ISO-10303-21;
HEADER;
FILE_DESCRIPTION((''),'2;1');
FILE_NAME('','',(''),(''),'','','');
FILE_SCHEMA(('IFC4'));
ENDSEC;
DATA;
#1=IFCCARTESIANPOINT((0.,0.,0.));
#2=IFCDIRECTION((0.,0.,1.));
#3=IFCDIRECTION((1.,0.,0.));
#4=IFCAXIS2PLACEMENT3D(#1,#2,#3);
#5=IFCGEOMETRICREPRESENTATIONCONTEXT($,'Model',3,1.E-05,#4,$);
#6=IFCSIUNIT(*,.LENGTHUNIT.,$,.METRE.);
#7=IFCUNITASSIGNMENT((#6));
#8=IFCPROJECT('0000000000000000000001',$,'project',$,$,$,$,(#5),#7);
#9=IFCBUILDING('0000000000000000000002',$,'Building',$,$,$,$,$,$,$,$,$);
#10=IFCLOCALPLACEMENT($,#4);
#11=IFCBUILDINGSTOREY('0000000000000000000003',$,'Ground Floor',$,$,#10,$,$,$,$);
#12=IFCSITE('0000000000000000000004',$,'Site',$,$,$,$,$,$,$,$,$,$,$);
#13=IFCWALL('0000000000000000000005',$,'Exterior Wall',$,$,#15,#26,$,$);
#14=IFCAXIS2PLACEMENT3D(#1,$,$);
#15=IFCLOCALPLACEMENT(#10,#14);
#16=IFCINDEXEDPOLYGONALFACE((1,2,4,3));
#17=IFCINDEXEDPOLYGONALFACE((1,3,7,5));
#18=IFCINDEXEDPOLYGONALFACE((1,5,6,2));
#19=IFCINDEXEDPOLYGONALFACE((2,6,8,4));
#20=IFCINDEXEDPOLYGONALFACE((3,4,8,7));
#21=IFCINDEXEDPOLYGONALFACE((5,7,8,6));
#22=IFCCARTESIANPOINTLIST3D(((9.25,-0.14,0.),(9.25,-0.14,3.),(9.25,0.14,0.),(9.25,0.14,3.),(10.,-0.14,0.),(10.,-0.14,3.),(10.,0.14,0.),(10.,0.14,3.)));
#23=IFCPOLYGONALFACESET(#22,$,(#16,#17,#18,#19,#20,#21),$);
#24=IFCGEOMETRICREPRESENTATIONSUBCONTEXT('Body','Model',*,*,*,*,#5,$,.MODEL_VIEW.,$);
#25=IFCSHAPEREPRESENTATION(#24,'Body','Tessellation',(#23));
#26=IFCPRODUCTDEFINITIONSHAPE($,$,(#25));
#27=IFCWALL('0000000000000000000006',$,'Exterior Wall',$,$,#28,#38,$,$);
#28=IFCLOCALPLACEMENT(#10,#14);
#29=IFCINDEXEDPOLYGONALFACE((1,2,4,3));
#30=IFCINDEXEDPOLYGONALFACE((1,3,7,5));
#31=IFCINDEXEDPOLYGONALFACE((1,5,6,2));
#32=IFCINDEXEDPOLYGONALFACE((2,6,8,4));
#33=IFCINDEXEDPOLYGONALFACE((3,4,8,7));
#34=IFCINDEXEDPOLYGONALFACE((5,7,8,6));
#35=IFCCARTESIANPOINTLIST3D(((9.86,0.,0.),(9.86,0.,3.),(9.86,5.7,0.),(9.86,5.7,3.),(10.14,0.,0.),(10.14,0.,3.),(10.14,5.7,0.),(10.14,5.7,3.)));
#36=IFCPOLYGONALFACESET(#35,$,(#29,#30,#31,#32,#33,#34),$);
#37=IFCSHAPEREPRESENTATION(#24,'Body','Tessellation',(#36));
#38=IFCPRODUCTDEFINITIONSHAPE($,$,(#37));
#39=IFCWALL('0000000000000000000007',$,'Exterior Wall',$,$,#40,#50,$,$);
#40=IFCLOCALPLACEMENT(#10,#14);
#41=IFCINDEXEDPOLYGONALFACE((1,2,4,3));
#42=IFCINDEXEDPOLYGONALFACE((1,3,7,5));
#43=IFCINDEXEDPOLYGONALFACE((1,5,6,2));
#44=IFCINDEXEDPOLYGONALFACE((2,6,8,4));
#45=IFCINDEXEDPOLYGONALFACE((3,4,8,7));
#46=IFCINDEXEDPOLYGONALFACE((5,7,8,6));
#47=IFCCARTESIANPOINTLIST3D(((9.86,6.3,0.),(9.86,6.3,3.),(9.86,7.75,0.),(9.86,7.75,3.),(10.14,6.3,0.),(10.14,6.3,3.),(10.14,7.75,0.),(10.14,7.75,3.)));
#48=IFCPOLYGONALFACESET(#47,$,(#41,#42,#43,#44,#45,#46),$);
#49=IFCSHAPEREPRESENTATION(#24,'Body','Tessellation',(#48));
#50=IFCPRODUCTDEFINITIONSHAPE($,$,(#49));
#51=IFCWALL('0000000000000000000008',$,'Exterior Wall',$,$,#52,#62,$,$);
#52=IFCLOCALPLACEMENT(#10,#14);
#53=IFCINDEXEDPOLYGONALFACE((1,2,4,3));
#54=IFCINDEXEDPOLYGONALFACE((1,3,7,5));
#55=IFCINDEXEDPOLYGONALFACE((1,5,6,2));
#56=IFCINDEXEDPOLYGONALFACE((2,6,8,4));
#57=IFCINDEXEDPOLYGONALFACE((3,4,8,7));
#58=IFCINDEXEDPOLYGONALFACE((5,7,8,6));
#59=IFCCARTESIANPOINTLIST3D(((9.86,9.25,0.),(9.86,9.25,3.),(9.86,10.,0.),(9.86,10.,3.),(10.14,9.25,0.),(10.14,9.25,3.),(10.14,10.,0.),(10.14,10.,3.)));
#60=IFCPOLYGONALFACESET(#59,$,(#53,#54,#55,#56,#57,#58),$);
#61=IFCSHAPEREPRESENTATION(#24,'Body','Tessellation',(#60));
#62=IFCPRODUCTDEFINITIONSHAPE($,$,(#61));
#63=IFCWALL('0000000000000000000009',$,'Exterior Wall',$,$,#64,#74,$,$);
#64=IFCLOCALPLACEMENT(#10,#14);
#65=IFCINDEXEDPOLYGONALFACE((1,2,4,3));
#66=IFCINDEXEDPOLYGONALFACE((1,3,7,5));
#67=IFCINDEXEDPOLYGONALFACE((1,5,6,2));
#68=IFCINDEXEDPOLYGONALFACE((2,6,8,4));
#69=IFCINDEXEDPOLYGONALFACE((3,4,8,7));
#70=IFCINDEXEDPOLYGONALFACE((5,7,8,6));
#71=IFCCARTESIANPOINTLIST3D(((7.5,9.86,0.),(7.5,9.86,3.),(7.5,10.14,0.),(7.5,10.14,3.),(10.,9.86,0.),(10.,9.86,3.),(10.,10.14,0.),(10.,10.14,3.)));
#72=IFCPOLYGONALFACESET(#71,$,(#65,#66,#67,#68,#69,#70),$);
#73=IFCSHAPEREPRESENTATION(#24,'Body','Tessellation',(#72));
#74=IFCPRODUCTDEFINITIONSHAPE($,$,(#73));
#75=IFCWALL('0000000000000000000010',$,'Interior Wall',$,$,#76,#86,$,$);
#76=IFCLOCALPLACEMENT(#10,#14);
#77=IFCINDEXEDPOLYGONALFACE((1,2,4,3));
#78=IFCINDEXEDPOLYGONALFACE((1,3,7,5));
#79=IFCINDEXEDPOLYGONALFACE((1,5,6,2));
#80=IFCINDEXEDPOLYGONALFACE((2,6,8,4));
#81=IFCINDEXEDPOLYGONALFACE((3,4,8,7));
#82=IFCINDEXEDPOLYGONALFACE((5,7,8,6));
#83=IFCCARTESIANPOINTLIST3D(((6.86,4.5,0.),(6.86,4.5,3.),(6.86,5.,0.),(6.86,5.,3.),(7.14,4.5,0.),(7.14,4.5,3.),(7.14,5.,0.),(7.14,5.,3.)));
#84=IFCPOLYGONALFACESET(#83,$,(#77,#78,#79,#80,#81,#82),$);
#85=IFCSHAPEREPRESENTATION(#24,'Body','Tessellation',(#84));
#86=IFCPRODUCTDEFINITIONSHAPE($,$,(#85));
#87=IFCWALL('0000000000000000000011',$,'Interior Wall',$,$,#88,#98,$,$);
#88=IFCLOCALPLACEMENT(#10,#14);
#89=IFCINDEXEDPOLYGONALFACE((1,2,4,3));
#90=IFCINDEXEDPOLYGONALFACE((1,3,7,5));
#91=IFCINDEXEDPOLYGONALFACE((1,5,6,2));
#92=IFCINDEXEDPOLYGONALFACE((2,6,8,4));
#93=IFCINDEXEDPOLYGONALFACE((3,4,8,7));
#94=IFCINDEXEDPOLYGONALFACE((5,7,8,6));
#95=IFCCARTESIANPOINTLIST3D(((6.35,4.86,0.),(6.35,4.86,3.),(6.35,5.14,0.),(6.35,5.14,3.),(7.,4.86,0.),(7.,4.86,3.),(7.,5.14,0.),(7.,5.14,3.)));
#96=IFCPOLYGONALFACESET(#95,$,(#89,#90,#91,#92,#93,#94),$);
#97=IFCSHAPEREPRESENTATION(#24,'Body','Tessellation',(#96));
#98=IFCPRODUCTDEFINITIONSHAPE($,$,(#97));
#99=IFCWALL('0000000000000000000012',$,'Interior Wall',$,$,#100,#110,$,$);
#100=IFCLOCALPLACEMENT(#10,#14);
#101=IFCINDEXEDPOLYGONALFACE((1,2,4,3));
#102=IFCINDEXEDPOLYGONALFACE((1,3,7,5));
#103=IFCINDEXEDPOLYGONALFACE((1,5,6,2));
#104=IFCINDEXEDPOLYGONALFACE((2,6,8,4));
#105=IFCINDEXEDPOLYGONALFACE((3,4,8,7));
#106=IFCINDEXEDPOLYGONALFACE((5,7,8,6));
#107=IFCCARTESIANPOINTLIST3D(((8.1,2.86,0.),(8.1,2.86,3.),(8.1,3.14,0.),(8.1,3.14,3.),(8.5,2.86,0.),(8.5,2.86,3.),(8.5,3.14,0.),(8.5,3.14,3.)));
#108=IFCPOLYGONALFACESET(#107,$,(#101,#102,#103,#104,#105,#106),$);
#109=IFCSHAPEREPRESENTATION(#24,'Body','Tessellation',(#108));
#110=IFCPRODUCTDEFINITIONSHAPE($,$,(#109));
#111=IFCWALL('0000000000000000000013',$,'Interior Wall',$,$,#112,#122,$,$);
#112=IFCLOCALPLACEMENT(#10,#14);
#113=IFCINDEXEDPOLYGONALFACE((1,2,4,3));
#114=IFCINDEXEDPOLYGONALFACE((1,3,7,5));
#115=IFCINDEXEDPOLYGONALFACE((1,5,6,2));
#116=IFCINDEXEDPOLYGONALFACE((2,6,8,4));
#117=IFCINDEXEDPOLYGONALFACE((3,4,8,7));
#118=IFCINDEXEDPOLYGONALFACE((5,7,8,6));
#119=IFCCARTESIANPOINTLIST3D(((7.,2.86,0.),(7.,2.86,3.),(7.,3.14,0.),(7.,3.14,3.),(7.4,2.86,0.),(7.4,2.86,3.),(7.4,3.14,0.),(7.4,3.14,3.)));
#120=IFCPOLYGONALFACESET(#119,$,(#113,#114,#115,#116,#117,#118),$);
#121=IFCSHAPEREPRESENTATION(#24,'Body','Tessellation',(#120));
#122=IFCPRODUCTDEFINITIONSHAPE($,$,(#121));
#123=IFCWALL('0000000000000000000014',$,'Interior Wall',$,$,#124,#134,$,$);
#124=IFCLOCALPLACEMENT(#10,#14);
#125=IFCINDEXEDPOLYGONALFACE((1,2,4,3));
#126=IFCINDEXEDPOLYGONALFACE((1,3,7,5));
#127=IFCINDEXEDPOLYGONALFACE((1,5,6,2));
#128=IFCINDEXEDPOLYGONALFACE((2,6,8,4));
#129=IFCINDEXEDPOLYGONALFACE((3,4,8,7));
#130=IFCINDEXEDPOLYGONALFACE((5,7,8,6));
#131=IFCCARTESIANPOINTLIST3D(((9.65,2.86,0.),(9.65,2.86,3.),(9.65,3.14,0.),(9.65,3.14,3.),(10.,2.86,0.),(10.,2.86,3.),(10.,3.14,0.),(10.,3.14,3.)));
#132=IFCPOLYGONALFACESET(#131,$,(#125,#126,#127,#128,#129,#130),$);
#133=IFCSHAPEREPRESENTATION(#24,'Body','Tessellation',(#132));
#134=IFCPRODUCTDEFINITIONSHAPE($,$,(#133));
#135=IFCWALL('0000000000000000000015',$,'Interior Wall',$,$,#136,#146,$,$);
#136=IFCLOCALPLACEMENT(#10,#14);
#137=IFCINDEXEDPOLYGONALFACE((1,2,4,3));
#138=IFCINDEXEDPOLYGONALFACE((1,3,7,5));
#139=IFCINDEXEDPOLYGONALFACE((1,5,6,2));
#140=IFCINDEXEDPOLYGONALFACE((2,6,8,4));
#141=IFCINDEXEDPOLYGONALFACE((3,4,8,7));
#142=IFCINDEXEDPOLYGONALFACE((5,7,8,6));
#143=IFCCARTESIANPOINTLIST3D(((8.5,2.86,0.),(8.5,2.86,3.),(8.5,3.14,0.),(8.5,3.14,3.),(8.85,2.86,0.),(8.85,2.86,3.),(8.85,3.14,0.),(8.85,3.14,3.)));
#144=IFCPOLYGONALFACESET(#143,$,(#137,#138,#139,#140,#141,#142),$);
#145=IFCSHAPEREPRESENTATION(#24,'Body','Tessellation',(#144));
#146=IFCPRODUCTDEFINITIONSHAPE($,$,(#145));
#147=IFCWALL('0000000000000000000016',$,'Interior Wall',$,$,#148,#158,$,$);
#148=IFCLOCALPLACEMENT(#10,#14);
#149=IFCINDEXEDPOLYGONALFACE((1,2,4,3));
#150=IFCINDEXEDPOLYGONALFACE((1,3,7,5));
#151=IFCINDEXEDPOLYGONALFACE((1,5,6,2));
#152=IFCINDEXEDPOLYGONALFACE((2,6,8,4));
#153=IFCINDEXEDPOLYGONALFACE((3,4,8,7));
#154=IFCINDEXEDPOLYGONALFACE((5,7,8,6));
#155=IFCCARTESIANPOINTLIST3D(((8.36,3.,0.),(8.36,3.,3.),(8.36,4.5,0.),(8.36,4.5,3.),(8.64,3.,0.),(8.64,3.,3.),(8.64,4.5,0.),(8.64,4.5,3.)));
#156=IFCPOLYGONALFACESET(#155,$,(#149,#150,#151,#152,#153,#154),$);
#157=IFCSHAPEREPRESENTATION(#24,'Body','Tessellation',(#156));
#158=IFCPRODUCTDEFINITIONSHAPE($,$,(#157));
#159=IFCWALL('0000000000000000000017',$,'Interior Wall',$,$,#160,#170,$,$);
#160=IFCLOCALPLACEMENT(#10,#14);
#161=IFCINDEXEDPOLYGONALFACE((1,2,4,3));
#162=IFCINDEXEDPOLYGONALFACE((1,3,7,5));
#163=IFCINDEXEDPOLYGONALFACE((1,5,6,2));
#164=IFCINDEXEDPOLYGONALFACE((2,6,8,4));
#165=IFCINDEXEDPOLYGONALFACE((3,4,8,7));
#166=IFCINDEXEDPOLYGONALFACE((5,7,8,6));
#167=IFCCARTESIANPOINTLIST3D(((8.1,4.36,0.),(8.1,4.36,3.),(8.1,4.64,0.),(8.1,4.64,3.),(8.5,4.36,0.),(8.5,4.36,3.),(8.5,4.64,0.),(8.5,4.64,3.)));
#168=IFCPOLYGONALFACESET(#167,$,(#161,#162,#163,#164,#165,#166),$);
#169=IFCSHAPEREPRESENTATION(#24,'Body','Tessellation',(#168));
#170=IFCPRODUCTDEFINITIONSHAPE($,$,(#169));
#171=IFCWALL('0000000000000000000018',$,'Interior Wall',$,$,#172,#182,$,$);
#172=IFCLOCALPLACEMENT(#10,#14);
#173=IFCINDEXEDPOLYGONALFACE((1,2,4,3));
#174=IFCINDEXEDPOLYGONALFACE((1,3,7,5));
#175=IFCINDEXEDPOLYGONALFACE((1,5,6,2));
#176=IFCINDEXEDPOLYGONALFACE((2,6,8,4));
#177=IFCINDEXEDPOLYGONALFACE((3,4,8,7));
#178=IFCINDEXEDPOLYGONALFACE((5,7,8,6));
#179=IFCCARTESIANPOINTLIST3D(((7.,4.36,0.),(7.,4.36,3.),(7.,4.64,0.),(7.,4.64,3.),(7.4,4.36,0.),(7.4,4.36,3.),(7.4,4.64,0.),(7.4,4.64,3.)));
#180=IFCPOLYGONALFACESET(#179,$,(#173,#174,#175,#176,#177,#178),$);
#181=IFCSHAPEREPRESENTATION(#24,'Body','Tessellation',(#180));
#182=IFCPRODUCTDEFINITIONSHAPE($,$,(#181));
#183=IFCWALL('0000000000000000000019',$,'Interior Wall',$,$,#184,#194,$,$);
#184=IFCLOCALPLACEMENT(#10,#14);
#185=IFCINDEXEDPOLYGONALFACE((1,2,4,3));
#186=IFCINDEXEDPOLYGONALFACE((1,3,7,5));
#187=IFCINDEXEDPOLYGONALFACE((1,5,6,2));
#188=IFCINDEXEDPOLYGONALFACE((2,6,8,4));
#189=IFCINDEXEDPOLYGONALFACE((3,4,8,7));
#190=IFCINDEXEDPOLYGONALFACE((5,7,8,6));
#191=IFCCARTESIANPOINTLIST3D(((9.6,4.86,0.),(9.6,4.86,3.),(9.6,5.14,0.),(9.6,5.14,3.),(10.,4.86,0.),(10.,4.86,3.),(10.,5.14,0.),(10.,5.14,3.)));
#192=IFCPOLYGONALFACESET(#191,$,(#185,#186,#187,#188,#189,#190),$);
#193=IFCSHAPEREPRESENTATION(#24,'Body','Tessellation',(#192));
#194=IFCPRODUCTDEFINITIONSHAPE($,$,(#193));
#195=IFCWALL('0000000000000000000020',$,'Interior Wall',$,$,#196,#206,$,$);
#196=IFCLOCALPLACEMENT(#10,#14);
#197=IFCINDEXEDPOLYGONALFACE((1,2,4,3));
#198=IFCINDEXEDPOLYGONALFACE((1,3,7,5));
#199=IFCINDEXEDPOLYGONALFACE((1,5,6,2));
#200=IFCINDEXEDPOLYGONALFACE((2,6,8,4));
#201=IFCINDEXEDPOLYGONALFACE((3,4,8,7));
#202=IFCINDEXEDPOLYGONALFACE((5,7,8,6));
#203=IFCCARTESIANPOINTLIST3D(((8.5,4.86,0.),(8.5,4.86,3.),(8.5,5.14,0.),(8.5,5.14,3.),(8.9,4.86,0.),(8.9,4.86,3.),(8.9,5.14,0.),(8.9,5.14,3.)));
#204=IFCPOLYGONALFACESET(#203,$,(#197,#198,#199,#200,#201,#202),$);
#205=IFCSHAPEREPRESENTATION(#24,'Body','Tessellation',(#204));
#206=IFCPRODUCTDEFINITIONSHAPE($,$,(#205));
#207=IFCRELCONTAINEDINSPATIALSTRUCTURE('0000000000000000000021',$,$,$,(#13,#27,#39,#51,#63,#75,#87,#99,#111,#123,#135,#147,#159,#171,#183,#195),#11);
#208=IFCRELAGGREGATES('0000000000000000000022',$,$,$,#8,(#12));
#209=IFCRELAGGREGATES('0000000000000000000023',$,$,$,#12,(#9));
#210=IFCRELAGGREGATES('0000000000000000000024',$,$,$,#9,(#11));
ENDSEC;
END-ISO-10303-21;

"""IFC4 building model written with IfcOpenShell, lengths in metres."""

from ifc_helpers import new_model, si_unit, frame, origin_with_axes, place, context, subcontext, project, spatial, indexed_curve, outline, extrude, element, save


model = new_model("IFC4")

# Units and contexts
model_context = context("Model", 3, precision=1e-05, world=origin_with_axes())
body_context = subcontext(model_context, "Body", "Model", "MODEL_VIEW")
ifc_project = project(units=[si_unit("LENGTHUNIT", "METRE")], contexts=[model_context])

# Site, building, storey
site = spatial("IfcSite", under=ifc_project, Name="Site")
building = spatial("IfcBuilding", under=site, Name="Building")
storey_placement = place(None, origin_with_axes())
storey = spatial("IfcBuildingStorey", under=building, at=storey_placement, Name="Ground Floor")

# Walls
wall_1_placement = place(storey_placement, frame((9.25, 0.0, 0.0), z_axis=(0.0, 0.0, 1.0), x_axis=(1.0, 0.0, 0.0)))
element("IfcWall", 1, at=wall_1_placement, inside=storey, Name="Exterior Wall", context=body_context, shape_type="SweptSolid", body=[
    extrude(outline(indexed_curve([(0.0, 0.0), (0.0, 0.28), (0.75, 0.28), (0.75, 0.0), (0.0, 0.0)], self_intersect=False)), frame((0.0, -0.14, 0.0), z_axis=(0.0, 0.0, 1.0), x_axis=(1.0, 0.0, 0.0)), (0.0, 0.0, 1.0), 3.0),
])
wall_2_placement = place(storey_placement, frame((10.0, 0.0, 0.0), z_axis=(0.0, 0.0, 1.0), x_axis=(0.0, 1.0, 0.0)))
element("IfcWall", 2, at=wall_2_placement, inside=storey, Name="Exterior Wall", context=body_context, shape_type="SweptSolid", body=[
    extrude(outline(indexed_curve([(0.0, 0.0), (0.0, 0.28), (5.7, 0.28), (5.7, 0.0), (0.0, 0.0)], self_intersect=False)), frame((0.0, -0.14, 0.0), z_axis=(0.0, 0.0, 1.0), x_axis=(1.0, 0.0, 0.0)), (0.0, 0.0, 1.0), 3.0),
])
wall_3_placement = place(storey_placement, frame((10.0, 6.3, 0.0), z_axis=(0.0, 0.0, 1.0), x_axis=(0.0, 1.0, 0.0)))
element("IfcWall", 3, at=wall_3_placement, inside=storey, Name="Exterior Wall", context=body_context, shape_type="SweptSolid", body=[
    extrude(outline(indexed_curve([(0.0, 0.0), (0.0, 0.28), (1.45, 0.28), (1.45, 0.0), (0.0, 0.0)], self_intersect=False)), frame((0.0, -0.14, 0.0), z_axis=(0.0, 0.0, 1.0), x_axis=(1.0, 0.0, 0.0)), (0.0, 0.0, 1.0), 3.0),
])
wall_4_placement = place(storey_placement, frame((10.0, 9.25, 0.0), z_axis=(0.0, 0.0, 1.0), x_axis=(0.0, 1.0, 0.0)))
element("IfcWall", 4, at=wall_4_placement, inside=storey, Name="Exterior Wall", context=body_context, shape_type="SweptSolid", body=[
    extrude(outline(indexed_curve([(0.0, 0.0), (0.0, 0.28), (0.75, 0.28), (0.75, 0.0), (0.0, 0.0)], self_intersect=False)), frame((0.0, -0.14, 0.0), z_axis=(0.0, 0.0, 1.0), x_axis=(1.0, 0.0, 0.0)), (0.0, 0.0, 1.0), 3.0),
])
wall_5_placement = place(storey_placement, frame((10.0, 10.0, 0.0), z_axis=(0.0, 0.0, 1.0), x_axis=(-1.0, 0.0, 0.0)))
element("IfcWall", 5, at=wall_5_placement, inside=storey, Name="Exterior Wall", context=body_context, shape_type="SweptSolid", body=[
    extrude(outline(indexed_curve([(0.0, 0.0), (0.0, 0.28), (2.5, 0.28), (2.5, 0.0), (0.0, 0.0)], self_intersect=False)), frame((0.0, -0.14, 0.0), z_axis=(0.0, 0.0, 1.0), x_axis=(1.0, 0.0, 0.0)), (0.0, 0.0, 1.0), 3.0),
])
wall_6_placement = place(storey_placement, frame((7.0, 4.5, 0.0), z_axis=(0.0, 0.0, 1.0), x_axis=(0.0, 1.0, 0.0)))
element("IfcWall", 6, at=wall_6_placement, inside=storey, Name="Interior Wall", context=body_context, shape_type="SweptSolid", body=[
    extrude(outline(indexed_curve([(0.0, 0.0), (0.0, 0.28), (0.5, 0.28), (0.5, 0.0), (0.0, 0.0)], self_intersect=False)), frame((0.0, -0.14, 0.0), z_axis=(0.0, 0.0, 1.0), x_axis=(1.0, 0.0, 0.0)), (0.0, 0.0, 1.0), 3.0),
])
wall_7_placement = place(storey_placement, frame((7.0, 5.0, 0.0), z_axis=(0.0, 0.0, 1.0), x_axis=(-1.0, 0.0, 0.0)))
element("IfcWall", 7, at=wall_7_placement, inside=storey, Name="Interior Wall", context=body_context, shape_type="SweptSolid", body=[
    extrude(outline(indexed_curve([(0.0, 0.0), (0.0, 0.28), (0.65, 0.28), (0.65, 0.0), (0.0, 0.0)], self_intersect=False)), frame((0.0, -0.14, 0.0), z_axis=(0.0, 0.0, 1.0), x_axis=(1.0, 0.0, 0.0)), (0.0, 0.0, 1.0), 3.0),
])
for number, where, z_axis, x_axis, name in (
    (8, (8.5, 3.0, 0.0), (0.0, 0.0, 1.0), (-1.0, 0.0, 0.0), "Interior Wall"),
    (9, (7.4, 3.0, 0.0), (0.0, 0.0, 1.0), (-1.0, 0.0, 0.0), "Interior Wall"),
):
    element("IfcWall", number, at=place(storey_placement, frame(where, z_axis=z_axis, x_axis=x_axis)), inside=storey, Name=name, context=body_context, shape_type="SweptSolid", body=[
        extrude(outline(indexed_curve([(0.0, 0.0), (0.0, 0.28), (0.4, 0.28), (0.4, 0.0), (0.0, 0.0)], self_intersect=False)), frame((0.0, -0.14, 0.0), z_axis=(0.0, 0.0, 1.0), x_axis=(1.0, 0.0, 0.0)), (0.0, 0.0, 1.0), 3.0),
    ])
for number, where, z_axis, x_axis, name in (
    (10, (10.0, 3.0, 0.0), (0.0, 0.0, 1.0), (-1.0, 0.0, 0.0), "Interior Wall"),
    (11, (8.85, 3.0, 0.0), (0.0, 0.0, 1.0), (-1.0, 0.0, 0.0), "Interior Wall"),
):
    element("IfcWall", number, at=place(storey_placement, frame(where, z_axis=z_axis, x_axis=x_axis)), inside=storey, Name=name, context=body_context, shape_type="SweptSolid", body=[
        extrude(outline(indexed_curve([(0.0, 0.0), (0.0, 0.28), (0.35, 0.28), (0.35, 0.0), (0.0, 0.0)], self_intersect=False)), frame((0.0, -0.14, 0.0), z_axis=(0.0, 0.0, 1.0), x_axis=(1.0, 0.0, 0.0)), (0.0, 0.0, 1.0), 3.0),
    ])
wall_8_placement = place(storey_placement, frame((8.5, 3.0, 0.0), z_axis=(0.0, 0.0, 1.0), x_axis=(0.0, 1.0, 0.0)))
element("IfcWall", 12, at=wall_8_placement, inside=storey, Name="Interior Wall", context=body_context, shape_type="SweptSolid", body=[
    extrude(outline(indexed_curve([(0.0, 0.0), (0.0, 0.28), (1.5, 0.28), (1.5, 0.0), (0.0, 0.0)], self_intersect=False)), frame((0.0, -0.14, 0.0), z_axis=(0.0, 0.0, 1.0), x_axis=(1.0, 0.0, 0.0)), (0.0, 0.0, 1.0), 3.0),
])
for number, where, z_axis, x_axis, name in (
    (13, (8.5, 4.5, 0.0), (0.0, 0.0, 1.0), (-1.0, 0.0, 0.0), "Interior Wall"),
    (14, (7.4, 4.5, 0.0), (0.0, 0.0, 1.0), (-1.0, 0.0, 0.0), "Interior Wall"),
    (15, (10.0, 5.0, 0.0), (0.0, 0.0, 1.0), (-1.0, 0.0, 0.0), "Interior Wall"),
    (16, (8.9, 5.0, 0.0), (0.0, 0.0, 1.0), (-1.0, 0.0, 0.0), "Interior Wall"),
):
    element("IfcWall", number, at=place(storey_placement, frame(where, z_axis=z_axis, x_axis=x_axis)), inside=storey, Name=name, context=body_context, shape_type="SweptSolid", body=[
        extrude(outline(indexed_curve([(0.0, 0.0), (0.0, 0.28), (0.4, 0.28), (0.4, 0.0), (0.0, 0.0)], self_intersect=False)), frame((0.0, -0.14, 0.0), z_axis=(0.0, 0.0, 1.0), x_axis=(1.0, 0.0, 0.0)), (0.0, 0.0, 1.0), 3.0),
    ])

save(model, "model.ifc")
